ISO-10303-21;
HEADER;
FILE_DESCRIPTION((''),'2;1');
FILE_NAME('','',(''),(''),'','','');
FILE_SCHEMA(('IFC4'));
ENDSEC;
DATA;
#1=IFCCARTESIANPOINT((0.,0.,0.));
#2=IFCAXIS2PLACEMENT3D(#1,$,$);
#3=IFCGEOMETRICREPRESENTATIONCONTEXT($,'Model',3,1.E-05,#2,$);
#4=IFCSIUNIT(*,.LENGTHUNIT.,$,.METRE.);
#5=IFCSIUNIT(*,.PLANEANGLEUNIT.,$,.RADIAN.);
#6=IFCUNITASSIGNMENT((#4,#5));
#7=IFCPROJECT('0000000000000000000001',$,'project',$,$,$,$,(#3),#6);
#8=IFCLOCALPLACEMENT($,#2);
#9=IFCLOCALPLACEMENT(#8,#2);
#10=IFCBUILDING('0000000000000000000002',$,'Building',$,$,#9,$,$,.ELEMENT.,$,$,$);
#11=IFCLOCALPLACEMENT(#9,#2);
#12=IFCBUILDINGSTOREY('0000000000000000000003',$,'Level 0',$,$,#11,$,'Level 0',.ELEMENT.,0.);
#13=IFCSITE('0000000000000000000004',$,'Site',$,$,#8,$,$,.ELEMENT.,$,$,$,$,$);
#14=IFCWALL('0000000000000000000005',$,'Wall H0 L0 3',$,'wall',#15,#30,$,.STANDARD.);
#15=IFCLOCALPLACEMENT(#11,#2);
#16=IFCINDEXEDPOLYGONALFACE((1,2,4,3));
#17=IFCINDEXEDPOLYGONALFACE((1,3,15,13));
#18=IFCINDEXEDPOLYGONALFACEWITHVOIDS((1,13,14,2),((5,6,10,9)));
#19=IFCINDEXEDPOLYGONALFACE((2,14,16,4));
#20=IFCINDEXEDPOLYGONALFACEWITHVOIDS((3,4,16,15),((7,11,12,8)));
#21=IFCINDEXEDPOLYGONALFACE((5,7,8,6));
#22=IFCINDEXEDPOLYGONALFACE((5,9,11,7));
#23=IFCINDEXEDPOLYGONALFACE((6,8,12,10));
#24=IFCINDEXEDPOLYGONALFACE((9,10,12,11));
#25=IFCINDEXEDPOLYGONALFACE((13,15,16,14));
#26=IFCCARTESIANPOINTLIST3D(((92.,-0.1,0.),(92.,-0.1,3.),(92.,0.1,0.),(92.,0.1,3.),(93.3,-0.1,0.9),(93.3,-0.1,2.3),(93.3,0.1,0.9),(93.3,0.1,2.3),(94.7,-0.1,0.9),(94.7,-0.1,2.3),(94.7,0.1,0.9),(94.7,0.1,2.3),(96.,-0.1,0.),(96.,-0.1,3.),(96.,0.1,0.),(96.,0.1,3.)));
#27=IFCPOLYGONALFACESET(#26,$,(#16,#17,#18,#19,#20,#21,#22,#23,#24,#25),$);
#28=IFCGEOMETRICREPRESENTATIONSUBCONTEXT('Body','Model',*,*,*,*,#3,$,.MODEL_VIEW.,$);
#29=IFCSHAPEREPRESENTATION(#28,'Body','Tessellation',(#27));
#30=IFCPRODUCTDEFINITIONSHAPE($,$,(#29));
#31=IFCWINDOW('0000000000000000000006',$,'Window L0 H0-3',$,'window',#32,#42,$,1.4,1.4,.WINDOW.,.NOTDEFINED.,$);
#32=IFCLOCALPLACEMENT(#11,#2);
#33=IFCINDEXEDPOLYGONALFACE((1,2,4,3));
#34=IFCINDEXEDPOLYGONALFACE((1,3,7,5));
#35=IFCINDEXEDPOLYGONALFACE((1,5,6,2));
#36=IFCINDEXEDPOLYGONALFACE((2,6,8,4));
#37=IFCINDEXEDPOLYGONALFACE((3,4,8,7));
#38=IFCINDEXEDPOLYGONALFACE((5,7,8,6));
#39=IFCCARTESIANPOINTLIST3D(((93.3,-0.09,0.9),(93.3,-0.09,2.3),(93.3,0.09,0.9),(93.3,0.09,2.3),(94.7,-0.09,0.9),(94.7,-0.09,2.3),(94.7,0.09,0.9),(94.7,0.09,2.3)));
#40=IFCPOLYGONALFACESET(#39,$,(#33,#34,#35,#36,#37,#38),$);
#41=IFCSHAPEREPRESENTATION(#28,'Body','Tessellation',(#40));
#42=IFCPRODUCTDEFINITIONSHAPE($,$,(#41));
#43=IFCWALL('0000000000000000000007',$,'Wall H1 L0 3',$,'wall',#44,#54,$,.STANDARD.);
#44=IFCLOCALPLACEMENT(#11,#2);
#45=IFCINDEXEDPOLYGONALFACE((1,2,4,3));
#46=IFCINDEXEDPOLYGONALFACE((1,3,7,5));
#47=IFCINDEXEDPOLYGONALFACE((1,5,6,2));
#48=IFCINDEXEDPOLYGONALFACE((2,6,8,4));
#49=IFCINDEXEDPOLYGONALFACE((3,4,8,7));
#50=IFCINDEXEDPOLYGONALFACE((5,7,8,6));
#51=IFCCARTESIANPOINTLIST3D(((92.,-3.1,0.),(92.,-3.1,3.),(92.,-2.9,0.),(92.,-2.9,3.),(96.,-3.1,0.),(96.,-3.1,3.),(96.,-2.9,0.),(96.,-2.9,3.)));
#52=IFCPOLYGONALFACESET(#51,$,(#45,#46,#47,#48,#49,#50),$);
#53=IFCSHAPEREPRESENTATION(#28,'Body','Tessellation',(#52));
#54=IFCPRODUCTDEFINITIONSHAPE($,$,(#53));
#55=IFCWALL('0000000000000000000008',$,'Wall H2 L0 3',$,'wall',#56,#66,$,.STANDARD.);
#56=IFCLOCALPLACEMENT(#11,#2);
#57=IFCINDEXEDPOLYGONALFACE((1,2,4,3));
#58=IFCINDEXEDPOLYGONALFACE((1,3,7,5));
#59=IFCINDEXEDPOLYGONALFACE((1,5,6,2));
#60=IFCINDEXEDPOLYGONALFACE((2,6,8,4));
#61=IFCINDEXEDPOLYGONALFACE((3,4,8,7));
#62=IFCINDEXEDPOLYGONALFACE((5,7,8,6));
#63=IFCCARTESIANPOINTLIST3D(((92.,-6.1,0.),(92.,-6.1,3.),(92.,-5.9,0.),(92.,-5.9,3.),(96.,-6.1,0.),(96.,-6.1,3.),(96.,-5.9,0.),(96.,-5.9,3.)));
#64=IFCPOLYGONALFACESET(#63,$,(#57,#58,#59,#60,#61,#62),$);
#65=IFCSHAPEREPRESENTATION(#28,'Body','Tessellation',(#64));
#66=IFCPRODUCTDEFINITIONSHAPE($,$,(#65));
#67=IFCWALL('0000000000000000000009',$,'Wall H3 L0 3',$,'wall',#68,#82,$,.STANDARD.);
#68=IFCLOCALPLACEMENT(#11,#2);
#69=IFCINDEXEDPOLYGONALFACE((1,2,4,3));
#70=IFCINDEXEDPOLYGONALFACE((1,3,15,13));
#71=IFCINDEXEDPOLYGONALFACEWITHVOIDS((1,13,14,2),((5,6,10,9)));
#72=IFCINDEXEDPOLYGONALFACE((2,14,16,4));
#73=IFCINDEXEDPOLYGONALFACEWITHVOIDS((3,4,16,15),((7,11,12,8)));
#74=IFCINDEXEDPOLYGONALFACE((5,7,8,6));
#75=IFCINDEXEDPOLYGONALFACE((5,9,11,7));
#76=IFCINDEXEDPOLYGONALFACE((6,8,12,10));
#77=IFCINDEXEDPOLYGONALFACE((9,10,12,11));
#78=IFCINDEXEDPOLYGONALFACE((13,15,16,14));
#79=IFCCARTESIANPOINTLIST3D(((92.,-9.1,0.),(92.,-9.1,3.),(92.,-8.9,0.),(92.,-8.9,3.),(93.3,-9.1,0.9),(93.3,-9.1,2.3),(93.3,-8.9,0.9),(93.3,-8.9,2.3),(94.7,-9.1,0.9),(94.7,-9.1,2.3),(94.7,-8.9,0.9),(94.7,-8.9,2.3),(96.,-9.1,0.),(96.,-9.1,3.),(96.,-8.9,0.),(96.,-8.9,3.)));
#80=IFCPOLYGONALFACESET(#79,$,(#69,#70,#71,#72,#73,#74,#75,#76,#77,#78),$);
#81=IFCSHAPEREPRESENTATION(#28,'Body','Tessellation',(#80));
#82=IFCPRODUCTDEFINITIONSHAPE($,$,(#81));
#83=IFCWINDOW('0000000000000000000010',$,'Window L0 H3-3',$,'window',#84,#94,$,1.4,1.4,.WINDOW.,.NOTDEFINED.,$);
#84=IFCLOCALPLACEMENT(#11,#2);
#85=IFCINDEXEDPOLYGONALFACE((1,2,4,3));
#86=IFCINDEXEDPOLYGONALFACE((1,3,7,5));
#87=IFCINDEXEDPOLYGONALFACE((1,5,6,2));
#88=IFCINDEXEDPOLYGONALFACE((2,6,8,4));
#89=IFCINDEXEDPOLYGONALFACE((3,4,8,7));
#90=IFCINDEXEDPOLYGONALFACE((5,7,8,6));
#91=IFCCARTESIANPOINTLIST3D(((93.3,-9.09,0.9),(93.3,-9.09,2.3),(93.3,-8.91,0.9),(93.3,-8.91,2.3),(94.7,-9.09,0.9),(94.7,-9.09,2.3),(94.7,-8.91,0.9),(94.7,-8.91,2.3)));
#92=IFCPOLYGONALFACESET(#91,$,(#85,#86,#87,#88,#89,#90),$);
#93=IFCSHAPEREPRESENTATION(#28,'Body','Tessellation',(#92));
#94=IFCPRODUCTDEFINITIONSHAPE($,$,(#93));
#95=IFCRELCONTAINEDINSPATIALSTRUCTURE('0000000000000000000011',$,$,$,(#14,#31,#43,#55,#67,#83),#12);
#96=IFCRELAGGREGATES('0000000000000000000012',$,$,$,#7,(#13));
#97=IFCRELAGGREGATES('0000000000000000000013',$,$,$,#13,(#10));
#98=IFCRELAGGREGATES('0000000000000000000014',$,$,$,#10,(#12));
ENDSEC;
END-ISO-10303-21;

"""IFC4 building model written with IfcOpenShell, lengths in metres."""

from ifc_helpers import new_model, si_unit, frame, frame_2d, origin, origin_2d, place, context, subcontext, project, spatial, rectangle, extrude, element, fill, save


model = new_model("IFC4")

# Units and contexts
model_context = context("Model", 3, precision=1e-05, world=origin())
body_context = subcontext(model_context, "Body", "Model", "MODEL_VIEW")
ifc_project = project(units=[si_unit("LENGTHUNIT", "METRE"), si_unit("PLANEANGLEUNIT", "RADIAN")], contexts=[model_context])

# Site, building, storey
site_placement = place(None, origin())
site = spatial("IfcSite", under=ifc_project, at=site_placement, Name="Site", CompositionType="ELEMENT")
building_placement = place(site_placement, origin())
building = spatial("IfcBuilding", under=site, at=building_placement, Name="Building", CompositionType="ELEMENT")
storey_placement = place(building_placement, origin())
storey = spatial("IfcBuildingStorey", under=building, at=storey_placement, Name="Level 0", LongName="Level 0", CompositionType="ELEMENT", Elevation=0.0)

# Wall, opening, window
wall_1_placement = place(storey_placement, frame((92.0, 0.0, 0.0), z_axis=(0.0, 0.0, 1.0), x_axis=(1.0, 0.0, 0.0)))
wall_1 = element("IfcWall", 1, at=wall_1_placement, inside=storey, Name="Wall H0 L0 3", ObjectType="wall", PredefinedType="STANDARD", context=body_context, shape_type="SweptSolid", body=[
    extrude(rectangle(XDim=4.0, YDim=0.2, at=frame_2d((2.0, 0.0))), origin(), (0.0, 0.0, 1.0), 3.0),
])
opening_1_placement = place(storey_placement, frame((94.0, 0.0, 0.9), z_axis=(0.0, 0.0, 1.0), x_axis=(1.0, 0.0, 0.0)))
opening_1 = element("IfcOpeningElement", 2, at=opening_1_placement, cuts=wall_1, ObjectType="Opening", PredefinedType="OPENING", context=body_context, shape_type="SweptSolid", body=[
    extrude(rectangle(XDim=1.4, YDim=0.22, at=origin_2d()), origin(), (0.0, 0.0, 1.0), 1.4),
])
window_1_placement = place(storey_placement, frame((94.0, 0.0, 0.9), z_axis=(0.0, 0.0, 1.0), x_axis=(1.0, 0.0, 0.0)))
window_1 = element("IfcWindow", 3, at=window_1_placement, inside=storey, Name="Window L0 H0-3", ObjectType="window", OverallHeight=1.4, OverallWidth=1.4, PartitioningType="NOTDEFINED", PredefinedType="WINDOW", context=body_context, shape_type="SweptSolid", body=[
    extrude(rectangle(XDim=1.4, YDim=0.18, at=origin_2d()), origin(), (0.0, 0.0, 1.0), 1.4),
])
fill(opening_1, window_1)

# Walls
for number, where, z_axis, x_axis, name in (
    (4, (92.0, -3.0, 0.0), (0.0, 0.0, 1.0), (1.0, 0.0, 0.0), "Wall H1 L0 3"),
    (5, (92.0, -6.0, 0.0), (0.0, 0.0, 1.0), (1.0, 0.0, 0.0), "Wall H2 L0 3"),
):
    element("IfcWall", number, at=place(storey_placement, frame(where, z_axis=z_axis, x_axis=x_axis)), inside=storey, Name=name, ObjectType="wall", PredefinedType="STANDARD", context=body_context, shape_type="SweptSolid", body=[
        extrude(rectangle(XDim=4.0, YDim=0.2, at=frame_2d((2.0, 0.0))), origin(), (0.0, 0.0, 1.0), 3.0),
    ])

# Wall, opening, window
wall_2_placement = place(storey_placement, frame((92.0, -9.0, 0.0), z_axis=(0.0, 0.0, 1.0), x_axis=(1.0, 0.0, 0.0)))
wall_2 = element("IfcWall", 6, at=wall_2_placement, inside=storey, Name="Wall H3 L0 3", ObjectType="wall", PredefinedType="STANDARD", context=body_context, shape_type="SweptSolid", body=[
    extrude(rectangle(XDim=4.0, YDim=0.2, at=frame_2d((2.0, 0.0))), origin(), (0.0, 0.0, 1.0), 3.0),
])
opening_2_placement = place(storey_placement, frame((94.0, -9.0, 0.9), z_axis=(0.0, 0.0, 1.0), x_axis=(1.0, 0.0, 0.0)))
opening_2 = element("IfcOpeningElement", 7, at=opening_2_placement, cuts=wall_2, ObjectType="Opening", PredefinedType="OPENING", context=body_context, shape_type="SweptSolid", body=[
    extrude(rectangle(XDim=1.4, YDim=0.22, at=origin_2d()), origin(), (0.0, 0.0, 1.0), 1.4),
])
window_2_placement = place(storey_placement, frame((94.0, -9.0, 0.9), z_axis=(0.0, 0.0, 1.0), x_axis=(1.0, 0.0, 0.0)))
window_2 = element("IfcWindow", 8, at=window_2_placement, inside=storey, Name="Window L0 H3-3", ObjectType="window", OverallHeight=1.4, OverallWidth=1.4, PartitioningType="NOTDEFINED", PredefinedType="WINDOW", context=body_context, shape_type="SweptSolid", body=[
    extrude(rectangle(XDim=1.4, YDim=0.18, at=origin_2d()), origin(), (0.0, 0.0, 1.0), 1.4),
])
fill(opening_2, window_2)

save(model, "model.ifc")
